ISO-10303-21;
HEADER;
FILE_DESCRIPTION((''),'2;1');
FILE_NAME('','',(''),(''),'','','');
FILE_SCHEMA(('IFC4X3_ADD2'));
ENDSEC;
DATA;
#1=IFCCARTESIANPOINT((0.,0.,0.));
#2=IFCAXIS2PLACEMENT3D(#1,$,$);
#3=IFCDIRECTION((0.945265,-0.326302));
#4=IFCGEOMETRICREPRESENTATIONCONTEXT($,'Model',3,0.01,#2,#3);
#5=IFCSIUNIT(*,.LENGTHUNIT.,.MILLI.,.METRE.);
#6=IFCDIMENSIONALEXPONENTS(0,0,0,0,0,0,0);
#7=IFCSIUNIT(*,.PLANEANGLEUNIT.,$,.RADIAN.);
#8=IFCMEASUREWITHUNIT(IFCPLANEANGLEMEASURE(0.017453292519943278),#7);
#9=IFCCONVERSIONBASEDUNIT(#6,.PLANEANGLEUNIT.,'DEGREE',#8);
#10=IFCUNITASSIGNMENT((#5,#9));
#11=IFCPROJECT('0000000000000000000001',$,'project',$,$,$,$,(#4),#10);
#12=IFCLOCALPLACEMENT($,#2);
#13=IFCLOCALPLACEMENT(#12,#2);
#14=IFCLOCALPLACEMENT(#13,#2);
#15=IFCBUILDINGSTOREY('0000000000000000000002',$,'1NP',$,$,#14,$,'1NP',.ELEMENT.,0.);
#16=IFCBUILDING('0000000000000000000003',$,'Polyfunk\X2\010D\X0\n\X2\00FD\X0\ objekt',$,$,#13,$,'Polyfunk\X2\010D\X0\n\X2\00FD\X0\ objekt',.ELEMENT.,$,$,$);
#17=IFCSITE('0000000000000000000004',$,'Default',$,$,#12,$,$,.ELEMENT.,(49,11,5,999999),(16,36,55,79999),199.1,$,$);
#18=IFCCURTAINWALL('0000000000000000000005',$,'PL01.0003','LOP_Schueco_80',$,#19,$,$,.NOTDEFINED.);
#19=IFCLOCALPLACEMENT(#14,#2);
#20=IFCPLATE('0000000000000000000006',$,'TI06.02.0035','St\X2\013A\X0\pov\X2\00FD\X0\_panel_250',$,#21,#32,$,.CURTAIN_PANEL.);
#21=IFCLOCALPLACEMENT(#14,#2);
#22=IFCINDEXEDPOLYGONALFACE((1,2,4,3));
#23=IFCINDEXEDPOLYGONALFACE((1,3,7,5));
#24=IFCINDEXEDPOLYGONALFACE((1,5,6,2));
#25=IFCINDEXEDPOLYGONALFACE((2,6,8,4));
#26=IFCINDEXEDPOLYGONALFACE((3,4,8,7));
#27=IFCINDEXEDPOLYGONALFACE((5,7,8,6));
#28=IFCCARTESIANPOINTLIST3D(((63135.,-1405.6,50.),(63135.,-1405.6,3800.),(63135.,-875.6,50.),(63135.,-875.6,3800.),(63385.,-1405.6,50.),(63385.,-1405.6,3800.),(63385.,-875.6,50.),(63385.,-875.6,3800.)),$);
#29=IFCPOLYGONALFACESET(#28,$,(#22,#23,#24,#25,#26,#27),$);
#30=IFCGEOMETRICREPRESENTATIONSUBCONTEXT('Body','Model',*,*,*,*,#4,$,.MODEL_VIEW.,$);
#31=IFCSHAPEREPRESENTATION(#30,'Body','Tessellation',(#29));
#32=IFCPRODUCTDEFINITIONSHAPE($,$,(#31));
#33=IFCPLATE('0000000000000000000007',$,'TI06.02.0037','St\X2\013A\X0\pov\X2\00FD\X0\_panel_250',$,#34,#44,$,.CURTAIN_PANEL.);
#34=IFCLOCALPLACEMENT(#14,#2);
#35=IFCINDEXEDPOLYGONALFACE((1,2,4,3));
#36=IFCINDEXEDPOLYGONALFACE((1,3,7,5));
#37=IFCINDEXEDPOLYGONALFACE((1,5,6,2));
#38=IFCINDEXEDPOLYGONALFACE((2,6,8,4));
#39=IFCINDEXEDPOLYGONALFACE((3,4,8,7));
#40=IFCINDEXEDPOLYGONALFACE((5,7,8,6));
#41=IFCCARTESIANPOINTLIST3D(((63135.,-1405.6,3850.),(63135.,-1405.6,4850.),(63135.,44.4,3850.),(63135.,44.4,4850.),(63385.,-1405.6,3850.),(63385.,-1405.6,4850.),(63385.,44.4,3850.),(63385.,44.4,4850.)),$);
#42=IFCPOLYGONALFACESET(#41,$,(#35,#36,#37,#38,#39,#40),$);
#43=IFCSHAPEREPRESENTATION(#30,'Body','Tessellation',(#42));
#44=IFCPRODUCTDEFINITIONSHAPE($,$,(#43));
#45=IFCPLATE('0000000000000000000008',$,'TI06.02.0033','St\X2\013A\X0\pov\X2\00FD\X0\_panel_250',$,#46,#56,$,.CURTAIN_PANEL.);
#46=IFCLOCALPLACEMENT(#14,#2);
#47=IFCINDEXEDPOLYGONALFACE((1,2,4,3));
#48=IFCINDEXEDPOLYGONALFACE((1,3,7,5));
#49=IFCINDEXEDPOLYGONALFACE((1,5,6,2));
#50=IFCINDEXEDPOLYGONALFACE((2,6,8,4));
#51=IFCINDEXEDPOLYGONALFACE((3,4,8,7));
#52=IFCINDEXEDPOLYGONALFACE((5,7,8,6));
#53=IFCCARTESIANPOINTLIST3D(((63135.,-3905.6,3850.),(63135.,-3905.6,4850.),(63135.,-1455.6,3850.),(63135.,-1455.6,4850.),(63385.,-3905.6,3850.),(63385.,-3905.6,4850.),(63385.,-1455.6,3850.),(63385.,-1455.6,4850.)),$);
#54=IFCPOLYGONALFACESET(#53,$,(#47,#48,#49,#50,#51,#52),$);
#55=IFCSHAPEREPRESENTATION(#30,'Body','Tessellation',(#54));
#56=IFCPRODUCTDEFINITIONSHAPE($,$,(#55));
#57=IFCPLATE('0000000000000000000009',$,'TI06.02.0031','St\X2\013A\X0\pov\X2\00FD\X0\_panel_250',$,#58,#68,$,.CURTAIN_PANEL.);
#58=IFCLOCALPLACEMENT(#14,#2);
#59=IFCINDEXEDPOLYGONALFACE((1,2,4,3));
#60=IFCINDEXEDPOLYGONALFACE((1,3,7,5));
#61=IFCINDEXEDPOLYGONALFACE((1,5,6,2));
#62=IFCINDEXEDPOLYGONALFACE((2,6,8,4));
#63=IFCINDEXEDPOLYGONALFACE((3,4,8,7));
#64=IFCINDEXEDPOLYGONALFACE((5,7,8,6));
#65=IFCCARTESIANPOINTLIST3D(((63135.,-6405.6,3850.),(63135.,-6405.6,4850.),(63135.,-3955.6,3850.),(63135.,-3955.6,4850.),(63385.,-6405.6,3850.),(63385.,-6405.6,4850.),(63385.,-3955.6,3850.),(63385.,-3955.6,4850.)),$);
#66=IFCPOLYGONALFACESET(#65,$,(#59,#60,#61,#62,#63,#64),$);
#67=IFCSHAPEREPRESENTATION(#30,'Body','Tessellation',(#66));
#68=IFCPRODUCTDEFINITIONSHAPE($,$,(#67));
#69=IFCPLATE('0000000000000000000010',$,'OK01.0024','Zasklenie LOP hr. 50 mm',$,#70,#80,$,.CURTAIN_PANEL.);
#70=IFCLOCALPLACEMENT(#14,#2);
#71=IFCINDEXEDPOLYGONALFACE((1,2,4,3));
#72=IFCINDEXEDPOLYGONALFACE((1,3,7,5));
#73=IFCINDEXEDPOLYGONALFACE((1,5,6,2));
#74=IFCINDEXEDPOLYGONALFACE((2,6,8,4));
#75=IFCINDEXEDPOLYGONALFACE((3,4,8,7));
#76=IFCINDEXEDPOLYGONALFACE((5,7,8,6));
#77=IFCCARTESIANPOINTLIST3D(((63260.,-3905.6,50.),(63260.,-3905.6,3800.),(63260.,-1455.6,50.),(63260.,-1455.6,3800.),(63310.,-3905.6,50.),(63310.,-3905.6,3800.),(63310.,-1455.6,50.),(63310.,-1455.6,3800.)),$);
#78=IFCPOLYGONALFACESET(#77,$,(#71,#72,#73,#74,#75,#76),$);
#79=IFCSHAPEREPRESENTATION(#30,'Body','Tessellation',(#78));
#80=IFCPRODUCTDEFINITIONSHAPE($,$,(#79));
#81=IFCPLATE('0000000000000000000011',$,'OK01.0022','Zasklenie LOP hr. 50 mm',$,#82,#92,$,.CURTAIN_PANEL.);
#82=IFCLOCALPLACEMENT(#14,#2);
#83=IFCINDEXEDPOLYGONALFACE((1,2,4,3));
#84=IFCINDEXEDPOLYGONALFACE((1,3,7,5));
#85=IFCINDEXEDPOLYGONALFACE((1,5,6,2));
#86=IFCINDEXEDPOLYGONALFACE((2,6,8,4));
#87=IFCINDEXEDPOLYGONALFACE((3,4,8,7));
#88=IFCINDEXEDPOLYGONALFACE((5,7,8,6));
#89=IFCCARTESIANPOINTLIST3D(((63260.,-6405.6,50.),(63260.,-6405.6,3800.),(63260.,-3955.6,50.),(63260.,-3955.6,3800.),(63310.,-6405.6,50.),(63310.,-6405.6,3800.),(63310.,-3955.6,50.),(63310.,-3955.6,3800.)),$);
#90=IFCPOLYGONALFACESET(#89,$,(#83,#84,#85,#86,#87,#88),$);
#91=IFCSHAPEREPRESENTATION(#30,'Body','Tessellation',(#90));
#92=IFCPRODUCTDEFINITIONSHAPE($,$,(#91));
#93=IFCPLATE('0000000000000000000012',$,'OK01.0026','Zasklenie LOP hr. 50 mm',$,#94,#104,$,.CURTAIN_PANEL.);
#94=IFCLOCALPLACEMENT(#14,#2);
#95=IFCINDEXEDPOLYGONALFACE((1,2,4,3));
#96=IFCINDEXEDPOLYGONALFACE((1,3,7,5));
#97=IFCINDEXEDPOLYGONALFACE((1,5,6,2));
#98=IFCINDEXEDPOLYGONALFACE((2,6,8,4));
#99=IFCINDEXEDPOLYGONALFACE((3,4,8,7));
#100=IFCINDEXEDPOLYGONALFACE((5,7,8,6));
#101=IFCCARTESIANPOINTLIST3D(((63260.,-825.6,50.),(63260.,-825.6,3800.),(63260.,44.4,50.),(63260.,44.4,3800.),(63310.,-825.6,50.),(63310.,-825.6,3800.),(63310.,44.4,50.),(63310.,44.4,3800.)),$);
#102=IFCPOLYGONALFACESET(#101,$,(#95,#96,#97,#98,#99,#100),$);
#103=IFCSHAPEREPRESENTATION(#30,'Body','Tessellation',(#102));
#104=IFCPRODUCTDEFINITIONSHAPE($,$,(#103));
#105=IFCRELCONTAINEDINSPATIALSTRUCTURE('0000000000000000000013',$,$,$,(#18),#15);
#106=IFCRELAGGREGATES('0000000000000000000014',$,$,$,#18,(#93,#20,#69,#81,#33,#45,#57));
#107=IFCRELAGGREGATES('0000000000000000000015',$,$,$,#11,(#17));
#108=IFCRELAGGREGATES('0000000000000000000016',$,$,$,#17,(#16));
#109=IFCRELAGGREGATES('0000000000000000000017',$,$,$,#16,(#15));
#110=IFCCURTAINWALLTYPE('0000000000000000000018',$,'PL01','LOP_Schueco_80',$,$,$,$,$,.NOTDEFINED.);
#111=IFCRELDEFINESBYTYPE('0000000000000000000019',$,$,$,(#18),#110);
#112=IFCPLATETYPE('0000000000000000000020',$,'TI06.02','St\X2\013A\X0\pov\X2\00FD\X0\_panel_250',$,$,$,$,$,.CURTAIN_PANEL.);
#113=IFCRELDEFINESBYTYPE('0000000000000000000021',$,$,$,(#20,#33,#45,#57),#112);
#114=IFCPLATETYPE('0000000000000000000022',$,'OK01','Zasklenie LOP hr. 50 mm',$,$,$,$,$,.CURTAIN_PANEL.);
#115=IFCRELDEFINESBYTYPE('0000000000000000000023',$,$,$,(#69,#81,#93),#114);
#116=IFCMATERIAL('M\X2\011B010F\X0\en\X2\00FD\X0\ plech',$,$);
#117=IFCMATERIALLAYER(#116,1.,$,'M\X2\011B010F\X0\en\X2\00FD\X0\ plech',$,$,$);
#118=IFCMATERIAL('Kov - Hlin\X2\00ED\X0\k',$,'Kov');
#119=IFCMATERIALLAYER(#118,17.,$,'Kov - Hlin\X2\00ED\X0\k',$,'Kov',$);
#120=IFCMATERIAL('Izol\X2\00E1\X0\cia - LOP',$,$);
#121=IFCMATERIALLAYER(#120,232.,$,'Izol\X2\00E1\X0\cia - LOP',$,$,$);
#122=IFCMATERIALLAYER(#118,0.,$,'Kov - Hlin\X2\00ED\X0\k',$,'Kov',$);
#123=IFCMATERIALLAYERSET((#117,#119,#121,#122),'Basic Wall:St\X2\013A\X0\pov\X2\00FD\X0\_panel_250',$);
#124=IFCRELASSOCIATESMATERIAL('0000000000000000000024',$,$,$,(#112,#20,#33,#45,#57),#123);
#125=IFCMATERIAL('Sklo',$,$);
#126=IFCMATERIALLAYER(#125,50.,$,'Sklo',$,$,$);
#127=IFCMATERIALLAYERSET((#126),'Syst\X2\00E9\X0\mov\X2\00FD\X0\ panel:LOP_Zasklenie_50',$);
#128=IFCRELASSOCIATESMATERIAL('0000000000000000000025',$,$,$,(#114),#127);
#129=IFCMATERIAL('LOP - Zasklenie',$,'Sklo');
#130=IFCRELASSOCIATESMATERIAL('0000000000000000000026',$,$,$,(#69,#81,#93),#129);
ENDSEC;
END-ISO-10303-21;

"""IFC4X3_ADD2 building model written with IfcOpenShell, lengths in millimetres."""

from ifc_helpers import new_model, entity, si_unit, converted_unit, direction, frame, frame_2d, origin, place, context, subcontext, project, spatial, rectangle, extrude, source, transform, mapped, material, layer, layer_set, layer_usage, type_object, type_shapes, element, aggregate, save


model = new_model("IFC4X3_ADD2")

# Units and contexts
model_context = context("Model", 3, precision=0.01, world=origin(), true_north=direction((0.945265, -0.326302)))
body_context = subcontext(model_context, "Body", "Model", "MODEL_VIEW")
ifc_project = project(units=[si_unit("LENGTHUNIT", "METRE", prefix="MILLI"), converted_unit("PLANEANGLEUNIT", "DEGREE", entity("IfcPlaneAngleMeasure", 0.017453292519943278), si_unit("PLANEANGLEUNIT", "RADIAN"), dimensions=[0, 0, 0, 0, 0, 0, 0])], contexts=[model_context])

# Site, building, storey
site_placement = place(None, origin())
site = spatial("IfcSite", under=ifc_project, at=site_placement, Name="Default", CompositionType="ELEMENT", RefLatitude=(49, 11, 5, 999999), RefLongitude=(16, 36, 55, 79999), RefElevation=199.1)
building_placement = place(site_placement, origin())
building = spatial("IfcBuilding", under=site, at=building_placement, Name="Polyfunkčný objekt", LongName="Polyfunkčný objekt", CompositionType="ELEMENT")
storey_placement = place(building_placement, origin())
storey = spatial("IfcBuildingStorey", under=building, at=storey_placement, Name="1NP", LongName="1NP", CompositionType="ELEMENT", Elevation=0.0)

# Curtain wall, plates
curtain_wall_type = type_object("IfcCurtainWallType", Name="PL01", Description="LOP_Schueco_80", PredefinedType="NOTDEFINED")
curtain_wall_placement = place(storey_placement, origin())
curtain_wall = element("IfcCurtainWall", 1, at=curtain_wall_placement, inside=storey, type_object=curtain_wall_type, Name="PL01.0003", Description="LOP_Schueco_80", PredefinedType="NOTDEFINED")
ifc_material_1 = material(Name="Měďený plech")
ifc_layer_1 = layer(ifc_material_1, 1.0, Name="Měďený plech")
ifc_material_2 = material(Name="Kov - Hliník", Category="Kov")
ifc_layer_2 = layer(ifc_material_2, 17.0, Name="Kov - Hliník", Category="Kov")
ifc_material_3 = material(Name="Izolácia - LOP")
ifc_layer_3 = layer(ifc_material_3, 232.0, Name="Izolácia - LOP")
ifc_layer_4 = layer(ifc_material_2, 0.0, Name="Kov - Hliník", Category="Kov")
ifc_layer_set_1 = layer_set([ifc_layer_1, ifc_layer_2, ifc_layer_3, ifc_layer_4], Name="Basic Wall:Stĺpový_panel_250")
ifc_layer_usage_1 = layer_usage(ifc_layer_set_1, "AXIS2", "NEGATIVE", 125.0)
plate_type_1 = type_object("IfcPlateType", Name="TI06.02", Description="Stĺpový_panel_250", PredefinedType="CURTAIN_PANEL", material=ifc_layer_set_1)
plate_1_placement = place(storey_placement, frame((63260.0, -875.6, 50.0), z_axis=(0.0, 0.0, 1.0), x_axis=(0.0, -1.0, 0.0)))
plate_1 = element("IfcPlate", 2, at=plate_1_placement, type_object=plate_type_1, material=ifc_layer_usage_1, Name="TI06.02.0035", Description="Stĺpový_panel_250", PredefinedType="CURTAIN_PANEL", context=body_context, shape_type="SweptSolid", body=[
    extrude(rectangle(XDim=250.0, YDim=530.0, at=frame_2d((0.0, 0.0), x_axis=(1.0, 0.0))), frame((265.0, 0.0, 0.0), z_axis=(0.0, 0.0, 1.0), x_axis=(0.0, 1.0, 0.0)), (0.0, 0.0, 1.0), 3750.0),
])
ifc_layer_usage_2 = layer_usage(ifc_layer_set_1, "AXIS2", "NEGATIVE", 125.0)
plate_2_placement = place(storey_placement, frame((63260.0, 44.4, 3850.0), z_axis=(0.0, 0.0, 1.0), x_axis=(0.0, -1.0, 0.0)))
plate_2 = element("IfcPlate", 3, at=plate_2_placement, type_object=plate_type_1, material=ifc_layer_usage_2, Name="TI06.02.0037", Description="Stĺpový_panel_250", PredefinedType="CURTAIN_PANEL", context=body_context, shape_type="SweptSolid", body=[
    extrude(rectangle(XDim=250.0, YDim=1450.0, at=frame_2d((0.0, 0.0), x_axis=(1.0, 0.0))), frame((725.0, 0.0, 0.0), z_axis=(0.0, 0.0, 1.0), x_axis=(0.0, 1.0, 0.0)), (0.0, 0.0, 1.0), 1000.0),
])
ifc_layer_usage_3 = layer_usage(ifc_layer_set_1, "AXIS2", "NEGATIVE", 125.0)
plate_3_placement = place(storey_placement, frame((63260.0, -1455.6, 3850.0), z_axis=(0.0, 0.0, 1.0), x_axis=(0.0, -1.0, 0.0)))
plate_3 = element("IfcPlate", 4, at=plate_3_placement, type_object=plate_type_1, material=ifc_layer_usage_3, Name="TI06.02.0033", Description="Stĺpový_panel_250", PredefinedType="CURTAIN_PANEL", context=body_context, shape_type="SweptSolid", body=[
    extrude(rectangle(XDim=250.0, YDim=2450.0, at=frame_2d((0.0, 0.0), x_axis=(1.0, 0.0))), frame((1225.0, 0.0, 0.0), z_axis=(0.0, 0.0, 1.0), x_axis=(0.0, 1.0, 0.0)), (0.0, 0.0, 1.0), 1000.0),
])
ifc_layer_usage_4 = layer_usage(ifc_layer_set_1, "AXIS2", "NEGATIVE", 125.0)
plate_4_placement = place(storey_placement, frame((63260.0, -3955.6, 3850.0), z_axis=(0.0, 0.0, 1.0), x_axis=(0.0, -1.0, 0.0)))
plate_4 = element("IfcPlate", 5, at=plate_4_placement, type_object=plate_type_1, material=ifc_layer_usage_4, Name="TI06.02.0031", Description="Stĺpový_panel_250", PredefinedType="CURTAIN_PANEL", context=body_context, shape_type="SweptSolid", body=[
    extrude(rectangle(XDim=250.0, YDim=2450.0, at=frame_2d((0.0, 0.0), x_axis=(1.0, 0.0))), frame((1225.0, 0.0, 0.0), z_axis=(0.0, 0.0, 1.0), x_axis=(0.0, 1.0, 0.0)), (0.0, 0.0, 1.0), 1000.0),
])
ifc_material_4 = material(Name="LOP - Zasklenie", Category="Sklo")
ifc_material_5 = material(Name="Sklo")
ifc_layer_5 = layer(ifc_material_5, 50.0, Name="Sklo")
ifc_layer_set_2 = layer_set([ifc_layer_5], Name="Systémový panel:LOP_Zasklenie_50")
plate_type_2 = type_object("IfcPlateType", Name="OK01", Description="Zasklenie LOP hr. 50 mm", PredefinedType="CURTAIN_PANEL", material=ifc_layer_set_2)
shared_shape_1 = source(origin(), body_context, "Body", "SweptSolid", [
    extrude(rectangle(XDim=3750.0, YDim=2450.0, at=frame_2d((-141.7, 0.0), x_axis=(1.0, 0.0))), frame((0.0, 0.0, 2016.7), z_axis=(0.0, 1.0, 0.0), x_axis=(0.0, 0.0, 1.0)), (0.0, 0.0, 1.0), 50.0),
])
plate_5_placement = place(curtain_wall_placement, frame((63260.0, -2680.6, 50.0), z_axis=(0.0, 0.0, 1.0), x_axis=(0.0, -1.0, 0.0)))
plate_5 = element("IfcPlate", 6, at=plate_5_placement, type_object=plate_type_2, material=ifc_material_4, Name="OK01.0024", Description="Zasklenie LOP hr. 50 mm", PredefinedType="CURTAIN_PANEL", context=body_context, shape_type="MappedRepresentation", body=[
    mapped(shared_shape_1, transform((0.0, 0.0, 0.0), scale=1.0)),
])
plate_6_placement = place(curtain_wall_placement, frame((63260.0, -5180.6, 50.0), z_axis=(0.0, 0.0, 1.0), x_axis=(0.0, -1.0, 0.0)))
plate_6 = element("IfcPlate", 7, at=plate_6_placement, type_object=plate_type_2, material=ifc_material_4, Name="OK01.0022", Description="Zasklenie LOP hr. 50 mm", PredefinedType="CURTAIN_PANEL", context=body_context, shape_type="MappedRepresentation", body=[
    mapped(shared_shape_1, transform((0.0, 0.0, 0.0), scale=1.0)),
])
shared_shape_2 = source(origin(), body_context, "Body", "SweptSolid", [
    extrude(rectangle(XDim=3750.0, YDim=870.0, at=frame_2d((-141.7, 0.0), x_axis=(1.0, 0.0))), frame((0.0, 0.0, 2016.7), z_axis=(0.0, 1.0, 0.0), x_axis=(0.0, 0.0, 1.0)), (0.0, 0.0, 1.0), 50.0),
])
type_shapes(plate_type_2, [shared_shape_1, shared_shape_2])
plate_7_placement = place(curtain_wall_placement, frame((63260.0, -390.6, 50.0), z_axis=(0.0, 0.0, 1.0), x_axis=(0.0, -1.0, 0.0)))
plate_7 = element("IfcPlate", 8, at=plate_7_placement, type_object=plate_type_2, material=ifc_material_4, Name="OK01.0026", Description="Zasklenie LOP hr. 50 mm", PredefinedType="CURTAIN_PANEL", context=body_context, shape_type="MappedRepresentation", body=[
    mapped(shared_shape_2, transform((0.0, 0.0, 0.0), scale=1.0)),
])
aggregate(curtain_wall, [plate_7, plate_1, plate_5, plate_6, plate_2, plate_3, plate_4])

save(model, "model.ifc")
